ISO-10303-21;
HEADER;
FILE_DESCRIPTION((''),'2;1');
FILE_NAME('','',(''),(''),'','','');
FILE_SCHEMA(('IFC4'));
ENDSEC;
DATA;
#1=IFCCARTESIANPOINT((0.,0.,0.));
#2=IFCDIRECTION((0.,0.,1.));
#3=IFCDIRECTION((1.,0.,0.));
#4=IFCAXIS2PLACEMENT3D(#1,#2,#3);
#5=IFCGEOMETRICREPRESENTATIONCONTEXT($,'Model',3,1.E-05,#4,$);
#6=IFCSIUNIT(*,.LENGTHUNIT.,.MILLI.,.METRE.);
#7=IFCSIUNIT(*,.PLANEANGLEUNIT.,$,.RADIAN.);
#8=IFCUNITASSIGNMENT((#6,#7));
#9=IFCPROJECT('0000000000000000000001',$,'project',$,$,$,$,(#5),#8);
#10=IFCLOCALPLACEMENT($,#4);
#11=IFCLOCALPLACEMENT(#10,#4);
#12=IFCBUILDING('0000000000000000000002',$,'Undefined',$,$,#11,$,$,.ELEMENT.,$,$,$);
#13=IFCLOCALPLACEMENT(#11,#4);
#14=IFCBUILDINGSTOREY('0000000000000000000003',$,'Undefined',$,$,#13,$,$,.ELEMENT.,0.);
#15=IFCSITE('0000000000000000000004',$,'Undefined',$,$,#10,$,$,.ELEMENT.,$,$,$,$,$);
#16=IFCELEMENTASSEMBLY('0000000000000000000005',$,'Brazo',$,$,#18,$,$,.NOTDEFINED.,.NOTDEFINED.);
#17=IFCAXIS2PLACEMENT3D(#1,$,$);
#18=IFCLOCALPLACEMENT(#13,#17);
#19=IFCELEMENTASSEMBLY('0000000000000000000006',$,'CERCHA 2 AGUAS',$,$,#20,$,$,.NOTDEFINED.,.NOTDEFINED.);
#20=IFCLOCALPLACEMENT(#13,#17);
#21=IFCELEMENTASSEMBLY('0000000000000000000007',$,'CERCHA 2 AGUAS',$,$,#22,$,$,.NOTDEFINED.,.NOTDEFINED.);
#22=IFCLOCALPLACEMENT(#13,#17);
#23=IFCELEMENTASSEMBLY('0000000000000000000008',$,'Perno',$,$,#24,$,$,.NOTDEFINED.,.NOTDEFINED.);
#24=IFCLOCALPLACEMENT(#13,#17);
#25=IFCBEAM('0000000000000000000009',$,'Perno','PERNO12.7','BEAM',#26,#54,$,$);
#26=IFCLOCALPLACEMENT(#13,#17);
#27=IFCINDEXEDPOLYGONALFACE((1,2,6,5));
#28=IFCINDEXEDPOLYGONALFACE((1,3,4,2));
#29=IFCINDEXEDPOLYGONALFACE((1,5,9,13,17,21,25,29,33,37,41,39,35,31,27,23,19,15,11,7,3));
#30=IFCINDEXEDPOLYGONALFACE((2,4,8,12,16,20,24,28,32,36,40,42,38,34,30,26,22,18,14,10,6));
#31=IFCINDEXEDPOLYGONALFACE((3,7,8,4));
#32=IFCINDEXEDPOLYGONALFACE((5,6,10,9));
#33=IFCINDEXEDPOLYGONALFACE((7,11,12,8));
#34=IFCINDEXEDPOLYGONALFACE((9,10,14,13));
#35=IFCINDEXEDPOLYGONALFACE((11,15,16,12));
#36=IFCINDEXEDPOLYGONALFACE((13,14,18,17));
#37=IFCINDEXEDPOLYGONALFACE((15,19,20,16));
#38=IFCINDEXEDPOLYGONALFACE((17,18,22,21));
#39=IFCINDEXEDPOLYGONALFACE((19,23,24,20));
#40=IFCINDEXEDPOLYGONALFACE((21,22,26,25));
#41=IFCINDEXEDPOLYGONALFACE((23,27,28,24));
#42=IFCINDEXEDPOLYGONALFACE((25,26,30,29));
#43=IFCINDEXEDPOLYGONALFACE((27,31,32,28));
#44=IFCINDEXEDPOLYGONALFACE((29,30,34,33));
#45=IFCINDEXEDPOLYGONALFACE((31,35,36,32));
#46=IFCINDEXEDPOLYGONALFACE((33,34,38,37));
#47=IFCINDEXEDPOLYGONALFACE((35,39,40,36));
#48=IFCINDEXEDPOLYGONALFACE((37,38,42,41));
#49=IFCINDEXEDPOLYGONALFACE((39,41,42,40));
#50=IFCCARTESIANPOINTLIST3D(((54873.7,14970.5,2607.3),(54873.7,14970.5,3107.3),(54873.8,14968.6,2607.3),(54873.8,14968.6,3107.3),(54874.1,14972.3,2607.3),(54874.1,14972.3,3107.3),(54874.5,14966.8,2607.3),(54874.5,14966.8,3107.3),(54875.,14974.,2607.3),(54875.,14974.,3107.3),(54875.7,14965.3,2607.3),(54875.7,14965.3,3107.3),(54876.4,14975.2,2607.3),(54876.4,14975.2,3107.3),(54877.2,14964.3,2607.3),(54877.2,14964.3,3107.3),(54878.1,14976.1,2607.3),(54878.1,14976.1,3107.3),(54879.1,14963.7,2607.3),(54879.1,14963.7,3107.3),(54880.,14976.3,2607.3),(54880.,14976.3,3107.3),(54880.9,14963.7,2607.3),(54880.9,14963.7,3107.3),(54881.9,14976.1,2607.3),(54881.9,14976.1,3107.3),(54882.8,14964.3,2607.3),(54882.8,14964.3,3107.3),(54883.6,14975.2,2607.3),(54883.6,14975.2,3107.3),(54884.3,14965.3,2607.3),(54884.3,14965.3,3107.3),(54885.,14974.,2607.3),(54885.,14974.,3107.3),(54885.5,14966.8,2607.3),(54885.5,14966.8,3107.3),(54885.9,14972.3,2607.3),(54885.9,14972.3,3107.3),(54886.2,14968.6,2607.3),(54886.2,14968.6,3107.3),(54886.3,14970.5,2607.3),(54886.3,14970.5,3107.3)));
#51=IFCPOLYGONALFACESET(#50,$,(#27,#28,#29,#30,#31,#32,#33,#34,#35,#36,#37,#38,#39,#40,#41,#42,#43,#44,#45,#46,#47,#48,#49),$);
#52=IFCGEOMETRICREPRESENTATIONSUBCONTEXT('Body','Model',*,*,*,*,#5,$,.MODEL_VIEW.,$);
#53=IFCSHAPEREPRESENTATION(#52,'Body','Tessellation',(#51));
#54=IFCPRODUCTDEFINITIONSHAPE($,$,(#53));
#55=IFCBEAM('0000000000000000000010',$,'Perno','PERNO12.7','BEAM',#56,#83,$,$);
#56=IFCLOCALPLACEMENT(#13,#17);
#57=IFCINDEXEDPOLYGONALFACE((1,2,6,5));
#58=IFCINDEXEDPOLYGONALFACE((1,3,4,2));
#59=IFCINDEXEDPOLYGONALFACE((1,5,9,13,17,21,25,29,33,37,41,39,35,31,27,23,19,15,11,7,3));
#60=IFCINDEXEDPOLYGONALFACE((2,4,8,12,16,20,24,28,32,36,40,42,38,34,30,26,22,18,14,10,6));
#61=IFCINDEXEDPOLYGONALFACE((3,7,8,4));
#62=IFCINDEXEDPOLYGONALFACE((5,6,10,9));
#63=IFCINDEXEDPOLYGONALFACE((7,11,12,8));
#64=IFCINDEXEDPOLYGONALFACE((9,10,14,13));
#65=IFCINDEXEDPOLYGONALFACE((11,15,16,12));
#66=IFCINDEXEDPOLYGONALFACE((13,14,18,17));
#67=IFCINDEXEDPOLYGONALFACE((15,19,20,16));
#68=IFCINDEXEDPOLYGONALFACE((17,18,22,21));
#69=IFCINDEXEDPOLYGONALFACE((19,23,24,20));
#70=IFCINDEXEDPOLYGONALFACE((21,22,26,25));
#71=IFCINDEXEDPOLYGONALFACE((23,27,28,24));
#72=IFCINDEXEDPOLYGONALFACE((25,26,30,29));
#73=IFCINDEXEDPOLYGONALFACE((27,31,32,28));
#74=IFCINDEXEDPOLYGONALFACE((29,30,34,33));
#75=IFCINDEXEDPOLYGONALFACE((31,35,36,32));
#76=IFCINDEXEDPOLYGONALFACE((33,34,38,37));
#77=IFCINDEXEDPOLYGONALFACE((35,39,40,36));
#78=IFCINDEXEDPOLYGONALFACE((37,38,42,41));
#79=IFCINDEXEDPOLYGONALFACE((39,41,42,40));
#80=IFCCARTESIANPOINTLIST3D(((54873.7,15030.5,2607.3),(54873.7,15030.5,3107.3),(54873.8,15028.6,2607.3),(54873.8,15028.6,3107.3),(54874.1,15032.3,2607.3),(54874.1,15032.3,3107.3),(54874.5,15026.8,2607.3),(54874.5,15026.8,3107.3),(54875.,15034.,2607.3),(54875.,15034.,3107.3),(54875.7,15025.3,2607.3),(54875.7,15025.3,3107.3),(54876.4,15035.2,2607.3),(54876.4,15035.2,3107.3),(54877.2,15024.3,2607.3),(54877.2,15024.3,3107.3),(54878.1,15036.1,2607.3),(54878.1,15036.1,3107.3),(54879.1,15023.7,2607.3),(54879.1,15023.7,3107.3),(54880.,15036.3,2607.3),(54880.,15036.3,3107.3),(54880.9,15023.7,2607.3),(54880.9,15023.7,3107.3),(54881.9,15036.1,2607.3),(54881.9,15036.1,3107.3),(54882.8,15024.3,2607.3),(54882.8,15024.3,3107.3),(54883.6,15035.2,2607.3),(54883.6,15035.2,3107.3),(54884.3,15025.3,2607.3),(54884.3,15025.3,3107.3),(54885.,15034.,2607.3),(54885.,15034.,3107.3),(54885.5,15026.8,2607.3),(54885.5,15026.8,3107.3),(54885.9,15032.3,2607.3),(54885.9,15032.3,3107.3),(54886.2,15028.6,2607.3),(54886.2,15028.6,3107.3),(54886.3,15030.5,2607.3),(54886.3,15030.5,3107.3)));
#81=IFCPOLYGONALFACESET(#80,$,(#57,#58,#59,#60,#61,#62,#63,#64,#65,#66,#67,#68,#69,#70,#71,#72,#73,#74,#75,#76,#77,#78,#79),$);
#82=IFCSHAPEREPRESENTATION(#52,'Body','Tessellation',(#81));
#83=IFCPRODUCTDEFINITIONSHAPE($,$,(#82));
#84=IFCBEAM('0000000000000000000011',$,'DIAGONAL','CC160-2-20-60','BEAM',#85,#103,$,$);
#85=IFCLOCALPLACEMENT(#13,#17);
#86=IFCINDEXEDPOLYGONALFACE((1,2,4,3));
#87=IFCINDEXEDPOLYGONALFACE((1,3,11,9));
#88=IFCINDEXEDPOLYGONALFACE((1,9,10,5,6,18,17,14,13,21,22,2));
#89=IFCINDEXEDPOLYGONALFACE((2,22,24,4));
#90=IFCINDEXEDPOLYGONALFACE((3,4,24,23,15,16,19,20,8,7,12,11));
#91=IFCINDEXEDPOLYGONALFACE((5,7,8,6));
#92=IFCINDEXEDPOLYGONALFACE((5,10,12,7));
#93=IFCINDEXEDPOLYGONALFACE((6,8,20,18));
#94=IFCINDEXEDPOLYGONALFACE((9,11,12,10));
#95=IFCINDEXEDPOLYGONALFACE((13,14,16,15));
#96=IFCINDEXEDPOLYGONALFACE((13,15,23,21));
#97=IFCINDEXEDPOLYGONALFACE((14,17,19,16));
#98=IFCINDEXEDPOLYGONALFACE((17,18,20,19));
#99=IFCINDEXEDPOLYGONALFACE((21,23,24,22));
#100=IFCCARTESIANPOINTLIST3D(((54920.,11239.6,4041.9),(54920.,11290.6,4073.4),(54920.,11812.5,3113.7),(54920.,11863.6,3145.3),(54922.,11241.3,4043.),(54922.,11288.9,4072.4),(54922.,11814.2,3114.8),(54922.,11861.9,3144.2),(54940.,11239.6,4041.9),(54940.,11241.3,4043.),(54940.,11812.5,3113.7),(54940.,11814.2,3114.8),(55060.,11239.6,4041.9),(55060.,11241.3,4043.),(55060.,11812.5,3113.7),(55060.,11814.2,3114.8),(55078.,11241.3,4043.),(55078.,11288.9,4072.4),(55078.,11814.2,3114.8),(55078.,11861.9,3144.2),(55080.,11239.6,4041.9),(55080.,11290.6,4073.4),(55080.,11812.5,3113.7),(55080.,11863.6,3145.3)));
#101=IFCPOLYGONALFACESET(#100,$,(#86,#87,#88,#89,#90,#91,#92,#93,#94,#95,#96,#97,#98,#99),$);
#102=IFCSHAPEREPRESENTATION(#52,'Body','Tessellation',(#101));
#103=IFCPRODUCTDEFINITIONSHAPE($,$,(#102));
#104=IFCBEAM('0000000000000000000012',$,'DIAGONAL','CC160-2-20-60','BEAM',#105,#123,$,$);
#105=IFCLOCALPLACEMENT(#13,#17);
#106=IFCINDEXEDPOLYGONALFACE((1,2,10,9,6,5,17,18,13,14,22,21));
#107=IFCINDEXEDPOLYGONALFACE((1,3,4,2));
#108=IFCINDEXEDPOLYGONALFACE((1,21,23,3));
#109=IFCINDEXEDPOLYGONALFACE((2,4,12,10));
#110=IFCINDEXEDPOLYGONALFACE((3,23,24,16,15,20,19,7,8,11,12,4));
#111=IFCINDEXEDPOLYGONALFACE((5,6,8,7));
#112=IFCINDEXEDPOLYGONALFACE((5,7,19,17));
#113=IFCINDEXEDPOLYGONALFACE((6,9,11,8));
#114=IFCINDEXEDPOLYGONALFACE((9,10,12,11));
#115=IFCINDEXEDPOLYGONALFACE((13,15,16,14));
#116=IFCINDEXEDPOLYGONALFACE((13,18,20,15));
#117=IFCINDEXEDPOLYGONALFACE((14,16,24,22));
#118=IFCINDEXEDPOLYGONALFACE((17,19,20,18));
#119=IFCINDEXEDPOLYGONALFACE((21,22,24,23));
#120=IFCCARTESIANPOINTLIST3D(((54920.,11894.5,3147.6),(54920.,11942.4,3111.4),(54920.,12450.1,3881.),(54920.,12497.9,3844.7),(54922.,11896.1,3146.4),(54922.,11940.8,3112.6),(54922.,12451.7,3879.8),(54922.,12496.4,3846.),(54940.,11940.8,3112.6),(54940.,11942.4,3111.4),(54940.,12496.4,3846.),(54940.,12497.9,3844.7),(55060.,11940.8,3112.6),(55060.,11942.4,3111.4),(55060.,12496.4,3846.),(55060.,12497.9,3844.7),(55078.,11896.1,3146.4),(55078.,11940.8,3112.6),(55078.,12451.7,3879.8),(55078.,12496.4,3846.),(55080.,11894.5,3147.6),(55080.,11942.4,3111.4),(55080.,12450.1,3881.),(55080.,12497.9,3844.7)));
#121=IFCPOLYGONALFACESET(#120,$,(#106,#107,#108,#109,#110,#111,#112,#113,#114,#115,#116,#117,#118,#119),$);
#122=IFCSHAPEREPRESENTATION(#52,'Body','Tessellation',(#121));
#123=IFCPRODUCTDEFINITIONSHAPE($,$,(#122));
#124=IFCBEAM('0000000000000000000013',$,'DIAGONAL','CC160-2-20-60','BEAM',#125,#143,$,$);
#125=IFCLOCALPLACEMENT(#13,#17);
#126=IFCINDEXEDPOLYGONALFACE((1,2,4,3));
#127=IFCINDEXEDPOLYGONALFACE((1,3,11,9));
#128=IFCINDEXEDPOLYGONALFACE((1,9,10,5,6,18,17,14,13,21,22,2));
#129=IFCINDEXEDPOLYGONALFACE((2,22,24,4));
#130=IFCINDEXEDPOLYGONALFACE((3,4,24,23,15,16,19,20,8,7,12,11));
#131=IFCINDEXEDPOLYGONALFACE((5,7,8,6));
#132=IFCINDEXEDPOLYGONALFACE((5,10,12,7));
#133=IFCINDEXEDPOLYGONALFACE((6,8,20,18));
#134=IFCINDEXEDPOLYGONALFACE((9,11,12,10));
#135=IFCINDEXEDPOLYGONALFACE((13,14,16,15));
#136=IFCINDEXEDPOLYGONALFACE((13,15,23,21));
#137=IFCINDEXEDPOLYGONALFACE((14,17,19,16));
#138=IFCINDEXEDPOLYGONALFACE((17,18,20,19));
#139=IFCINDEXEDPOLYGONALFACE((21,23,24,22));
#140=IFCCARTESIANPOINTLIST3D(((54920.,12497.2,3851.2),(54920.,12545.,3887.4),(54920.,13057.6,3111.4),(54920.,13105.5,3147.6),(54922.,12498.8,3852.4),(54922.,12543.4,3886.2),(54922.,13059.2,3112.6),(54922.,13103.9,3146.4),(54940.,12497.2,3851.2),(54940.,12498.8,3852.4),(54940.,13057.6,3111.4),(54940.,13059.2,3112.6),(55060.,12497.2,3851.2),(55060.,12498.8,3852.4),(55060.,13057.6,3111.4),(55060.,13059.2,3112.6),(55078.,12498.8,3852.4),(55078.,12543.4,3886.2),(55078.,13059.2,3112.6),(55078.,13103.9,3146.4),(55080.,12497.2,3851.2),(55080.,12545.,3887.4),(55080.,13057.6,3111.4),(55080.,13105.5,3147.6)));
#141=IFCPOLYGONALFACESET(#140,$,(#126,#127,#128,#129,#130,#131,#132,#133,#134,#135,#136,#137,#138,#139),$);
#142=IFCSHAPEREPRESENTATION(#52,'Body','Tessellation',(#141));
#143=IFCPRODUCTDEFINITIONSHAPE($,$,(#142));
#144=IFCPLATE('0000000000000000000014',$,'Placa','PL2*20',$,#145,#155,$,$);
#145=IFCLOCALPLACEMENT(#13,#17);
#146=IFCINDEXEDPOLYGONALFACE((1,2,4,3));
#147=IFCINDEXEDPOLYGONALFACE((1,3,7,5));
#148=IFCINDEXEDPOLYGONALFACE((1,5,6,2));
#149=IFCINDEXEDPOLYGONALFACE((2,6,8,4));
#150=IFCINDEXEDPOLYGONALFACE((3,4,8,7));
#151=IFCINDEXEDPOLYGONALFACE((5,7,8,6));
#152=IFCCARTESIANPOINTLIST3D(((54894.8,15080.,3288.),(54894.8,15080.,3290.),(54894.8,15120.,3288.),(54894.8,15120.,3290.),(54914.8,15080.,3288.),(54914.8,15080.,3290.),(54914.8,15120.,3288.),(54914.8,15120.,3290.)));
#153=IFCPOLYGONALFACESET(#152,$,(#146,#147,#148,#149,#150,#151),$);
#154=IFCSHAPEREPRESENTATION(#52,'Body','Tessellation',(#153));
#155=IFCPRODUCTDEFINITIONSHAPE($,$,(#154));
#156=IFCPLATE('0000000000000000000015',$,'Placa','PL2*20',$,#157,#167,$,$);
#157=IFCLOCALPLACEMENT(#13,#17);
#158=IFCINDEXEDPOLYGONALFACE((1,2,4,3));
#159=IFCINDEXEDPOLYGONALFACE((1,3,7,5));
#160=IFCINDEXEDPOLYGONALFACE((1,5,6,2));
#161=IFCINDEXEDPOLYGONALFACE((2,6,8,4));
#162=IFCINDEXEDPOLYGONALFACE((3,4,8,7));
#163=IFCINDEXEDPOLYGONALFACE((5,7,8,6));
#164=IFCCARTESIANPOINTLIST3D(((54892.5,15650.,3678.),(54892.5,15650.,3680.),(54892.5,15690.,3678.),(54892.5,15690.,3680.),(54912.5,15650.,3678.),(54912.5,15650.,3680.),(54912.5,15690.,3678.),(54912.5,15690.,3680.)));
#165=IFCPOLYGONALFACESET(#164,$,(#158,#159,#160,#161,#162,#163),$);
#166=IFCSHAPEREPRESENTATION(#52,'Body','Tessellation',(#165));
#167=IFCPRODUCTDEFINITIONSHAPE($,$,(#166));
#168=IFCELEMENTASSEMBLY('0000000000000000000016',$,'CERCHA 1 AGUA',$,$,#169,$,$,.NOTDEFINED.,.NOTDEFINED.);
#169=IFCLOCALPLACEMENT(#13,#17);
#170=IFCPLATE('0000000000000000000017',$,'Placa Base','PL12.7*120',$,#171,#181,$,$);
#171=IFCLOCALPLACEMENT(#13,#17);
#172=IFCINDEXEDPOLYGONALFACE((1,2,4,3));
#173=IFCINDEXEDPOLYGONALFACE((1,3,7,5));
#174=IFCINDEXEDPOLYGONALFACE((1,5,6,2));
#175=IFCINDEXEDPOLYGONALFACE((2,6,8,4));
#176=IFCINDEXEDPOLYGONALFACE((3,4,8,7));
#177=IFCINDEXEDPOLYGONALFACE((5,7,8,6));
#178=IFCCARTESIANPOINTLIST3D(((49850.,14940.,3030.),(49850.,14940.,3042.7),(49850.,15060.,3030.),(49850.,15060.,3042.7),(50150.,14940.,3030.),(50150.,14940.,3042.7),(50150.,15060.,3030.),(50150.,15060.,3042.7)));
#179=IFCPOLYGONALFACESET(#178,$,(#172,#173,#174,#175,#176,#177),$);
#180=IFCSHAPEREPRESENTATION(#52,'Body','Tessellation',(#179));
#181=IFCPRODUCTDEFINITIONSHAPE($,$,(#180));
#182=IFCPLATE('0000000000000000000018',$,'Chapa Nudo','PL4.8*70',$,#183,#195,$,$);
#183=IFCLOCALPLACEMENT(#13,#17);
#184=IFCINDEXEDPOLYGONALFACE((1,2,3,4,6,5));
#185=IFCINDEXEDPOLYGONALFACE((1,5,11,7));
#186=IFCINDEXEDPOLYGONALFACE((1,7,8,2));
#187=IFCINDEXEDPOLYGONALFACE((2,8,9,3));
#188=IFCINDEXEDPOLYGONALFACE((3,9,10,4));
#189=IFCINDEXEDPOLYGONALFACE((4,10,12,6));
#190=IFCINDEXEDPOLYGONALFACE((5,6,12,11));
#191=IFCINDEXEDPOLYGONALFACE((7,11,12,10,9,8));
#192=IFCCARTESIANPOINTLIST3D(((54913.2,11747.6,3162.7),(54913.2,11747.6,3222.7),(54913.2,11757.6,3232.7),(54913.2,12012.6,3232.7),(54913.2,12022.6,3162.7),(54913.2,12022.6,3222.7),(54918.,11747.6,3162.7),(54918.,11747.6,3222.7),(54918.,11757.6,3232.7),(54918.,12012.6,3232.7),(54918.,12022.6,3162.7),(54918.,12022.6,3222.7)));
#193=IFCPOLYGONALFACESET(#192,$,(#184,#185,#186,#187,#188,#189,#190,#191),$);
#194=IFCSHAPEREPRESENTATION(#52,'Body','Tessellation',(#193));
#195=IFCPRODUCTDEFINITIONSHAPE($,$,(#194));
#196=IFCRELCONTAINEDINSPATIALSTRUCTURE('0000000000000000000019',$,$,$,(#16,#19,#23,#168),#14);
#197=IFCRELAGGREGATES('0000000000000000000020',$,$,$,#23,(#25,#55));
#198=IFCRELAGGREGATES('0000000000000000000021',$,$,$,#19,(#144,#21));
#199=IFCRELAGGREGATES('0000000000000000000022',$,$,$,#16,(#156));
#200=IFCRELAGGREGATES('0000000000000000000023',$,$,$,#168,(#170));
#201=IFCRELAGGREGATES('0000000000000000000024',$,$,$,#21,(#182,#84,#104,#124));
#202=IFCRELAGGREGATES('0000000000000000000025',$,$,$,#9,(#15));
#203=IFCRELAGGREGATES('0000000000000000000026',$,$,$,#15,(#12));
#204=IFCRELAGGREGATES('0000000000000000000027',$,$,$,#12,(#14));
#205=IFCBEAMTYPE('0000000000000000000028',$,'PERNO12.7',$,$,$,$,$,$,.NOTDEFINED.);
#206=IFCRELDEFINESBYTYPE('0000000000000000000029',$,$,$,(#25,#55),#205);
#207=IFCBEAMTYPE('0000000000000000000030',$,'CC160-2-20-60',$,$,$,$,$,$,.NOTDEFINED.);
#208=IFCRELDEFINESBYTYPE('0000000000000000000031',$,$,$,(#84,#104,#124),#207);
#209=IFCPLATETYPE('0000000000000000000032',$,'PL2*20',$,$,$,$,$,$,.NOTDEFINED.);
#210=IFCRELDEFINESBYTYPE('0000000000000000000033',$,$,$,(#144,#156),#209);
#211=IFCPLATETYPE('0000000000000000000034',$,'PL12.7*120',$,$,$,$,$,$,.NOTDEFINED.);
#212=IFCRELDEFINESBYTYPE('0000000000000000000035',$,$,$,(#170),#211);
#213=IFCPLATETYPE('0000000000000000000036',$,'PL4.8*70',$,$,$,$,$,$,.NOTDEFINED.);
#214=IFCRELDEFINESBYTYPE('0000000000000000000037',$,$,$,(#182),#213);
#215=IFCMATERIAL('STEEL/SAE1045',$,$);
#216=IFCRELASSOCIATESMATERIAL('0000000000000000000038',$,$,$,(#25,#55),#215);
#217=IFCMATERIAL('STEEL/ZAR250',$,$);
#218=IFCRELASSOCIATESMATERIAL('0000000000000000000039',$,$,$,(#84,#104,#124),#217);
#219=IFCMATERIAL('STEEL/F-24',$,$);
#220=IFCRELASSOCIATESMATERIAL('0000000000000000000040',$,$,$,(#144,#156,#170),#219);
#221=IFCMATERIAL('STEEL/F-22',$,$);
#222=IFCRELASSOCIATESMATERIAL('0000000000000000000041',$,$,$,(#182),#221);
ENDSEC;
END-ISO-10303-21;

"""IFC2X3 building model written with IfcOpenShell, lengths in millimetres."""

from ifc_helpers import new_model, si_unit, frame, origin_with_axes, origin_2d_with_axis, place, context, subcontext, project, spatial, polyline, circle, c_section, outline, extrude, material, type_object, element, aggregate, save


model = new_model("IFC2X3")

# Units and contexts
model_context = context("Model", 3, precision=1e-05, world=origin_with_axes())
body_context = subcontext(model_context, "Body", "Model", "MODEL_VIEW")
ifc_project = project(units=[si_unit("LENGTHUNIT", "METRE", prefix="MILLI"), si_unit("PLANEANGLEUNIT", "RADIAN")], contexts=[model_context])

# Site, building, storey
site_placement = place(None, origin_with_axes())
site = spatial("IfcSite", under=ifc_project, at=site_placement, Name="Undefined", CompositionType="ELEMENT")
building_placement = place(site_placement, origin_with_axes())
building = spatial("IfcBuilding", under=site, at=building_placement, Name="Undefined", CompositionType="ELEMENT")
storey_placement = place(building_placement, origin_with_axes())
storey = spatial("IfcBuildingStorey", under=building, at=storey_placement, Name="Undefined", CompositionType="ELEMENT", Elevation=0.0)

# Element assembly
assembly_1_placement = place(storey_placement, origin_with_axes())
assembly_1 = element("IfcElementAssembly", 1, at=assembly_1_placement, inside=storey, Name="Brazo", AssemblyPlace="NOTDEFINED", PredefinedType="NOTDEFINED")
ifc_material_1 = material(Name="STEEL/ZAR250")

# Element assemblies
assembly_2_placement = place(storey_placement, origin_with_axes())
assembly_2 = element("IfcElementAssembly", 2, at=assembly_2_placement, inside=storey, Name="CERCHA 2 AGUAS", AssemblyPlace="NOTDEFINED", PredefinedType="NOTDEFINED")
assembly_3_placement = place(assembly_2_placement, origin_with_axes())
assembly_3 = element("IfcElementAssembly", 3, at=assembly_3_placement, Name="CERCHA 2 AGUAS", AssemblyPlace="NOTDEFINED", PredefinedType="NOTDEFINED")
ifc_material_2 = material(Name="STEEL/F-22")

# Element assembly, beams
assembly_4_placement = place(storey_placement, origin_with_axes())
assembly_4 = element("IfcElementAssembly", 4, at=assembly_4_placement, inside=storey, Name="Perno", AssemblyPlace="NOTDEFINED", PredefinedType="NOTDEFINED")
ifc_material_3 = material(Name="STEEL/SAE1045")
beam_type_1 = type_object("IfcBeamType", Name="PERNO12.7", PredefinedType="NOTDEFINED")
beam_1_placement = place(assembly_4_placement, frame((54880.0, 14970.0, 3107.3), z_axis=(-1.0, 0.0, 0.0), x_axis=(0.0, 0.0, -1.0)))
beam_1 = element("IfcBeam", 5, at=beam_1_placement, type_object=beam_type_1, material=ifc_material_3, Name="Perno", Description="PERNO12.7", ObjectType="BEAM", context=body_context, shape_type="SweptSolid", body=[
    extrude(circle(Radius=6.3, at=origin_2d_with_axis()), frame((500.0, 0.0, 0.0), z_axis=(-1.0, 0.0, 0.0), x_axis=(0.0, -1.0, 0.0)), (0.0, 0.0, 1.0), 500.0),
])
beam_2_placement = place(assembly_4_placement, frame((54880.0, 15030.0, 3107.3), z_axis=(-1.0, 0.0, 0.0), x_axis=(0.0, 0.0, -1.0)))
beam_2 = element("IfcBeam", 6, at=beam_2_placement, type_object=beam_type_1, material=ifc_material_3, Name="Perno", Description="PERNO12.7", ObjectType="BEAM", context=body_context, shape_type="SweptSolid", body=[
    extrude(circle(Radius=6.3, at=origin_2d_with_axis()), frame((500.0, 0.0, 0.0), z_axis=(-1.0, 0.0, 0.0), x_axis=(0.0, -1.0, 0.0)), (0.0, 0.0, 1.0), 500.0),
])
aggregate(assembly_4, [beam_1, beam_2])

# Beams
beam_type_2 = type_object("IfcBeamType", Name="CC160-2-20-60", PredefinedType="NOTDEFINED")
beam_3_placement = place(assembly_3_placement, frame((55000.0, 11838.1, 3129.5), z_axis=(-1.0, 0.0, 0.0), x_axis=(0.0, -0.525269, 0.850936)))
beam_3 = element("IfcBeam", 7, at=beam_3_placement, type_object=beam_type_2, material=ifc_material_1, Name="DIAGONAL", Description="CC160-2-20-60", ObjectType="BEAM", context=body_context, shape_type="SweptSolid", body=[
    extrude(c_section(Depth=160.0, Width=60.0, WallThickness=2.0, Girth=20.0, at=origin_2d_with_axis()), frame((1090.8, 0.0, 0.0), z_axis=(-1.0, 0.0, 0.0), x_axis=(0.0, -1.0, 0.0)), (0.0, 0.0, 1.0), 1090.8),
])
beam_4_placement = place(assembly_3_placement, frame((55000.0, 12474.0, 3862.9), z_axis=(-1.0, 0.0, 0.0), x_axis=(0.0, -0.603858, -0.797092)))
beam_4 = element("IfcBeam", 8, at=beam_4_placement, type_object=beam_type_2, material=ifc_material_1, Name="DIAGONAL", Description="CC160-2-20-60", ObjectType="BEAM", context=body_context, shape_type="SweptSolid", body=[
    extrude(c_section(Depth=160.0, Width=60.0, WallThickness=2.0, Girth=20.0, at=origin_2d_with_axis()), frame((920.0, 0.0, 0.0), z_axis=(-1.0, 0.0, 0.0), x_axis=(0.0, -1.0, 0.0)), (0.0, 0.0, 1.0), 920.0),
])
beam_5_placement = place(assembly_3_placement, frame((55000.0, 13081.5, 3129.5), z_axis=(-1.0, 0.0, 0.0), x_axis=(0.0, -0.603858, 0.797092)))
beam_5 = element("IfcBeam", 9, at=beam_5_placement, type_object=beam_type_2, material=ifc_material_1, Name="DIAGONAL", Description="CC160-2-20-60", ObjectType="BEAM", context=body_context, shape_type="SweptSolid", body=[
    extrude(c_section(Depth=160.0, Width=60.0, WallThickness=2.0, Girth=20.0, at=origin_2d_with_axis()), frame((928.1, 0.0, 0.0), z_axis=(-1.0, 0.0, 0.0), x_axis=(0.0, -1.0, 0.0)), (0.0, 0.0, 1.0), 928.1),
])

# Plates
ifc_material_4 = material(Name="STEEL/F-24")
plate_type_1 = type_object("IfcPlateType", Name="PL2*20", PredefinedType="NOTDEFINED")
plate_1_placement = place(assembly_2_placement, frame((54914.8, 15120.0, 3289.0), z_axis=(0.0, -0.000121, -1.0), x_axis=(0.000085, -1.0, 0.000121)))
plate_1 = element("IfcPlate", 10, at=plate_1_placement, type_object=plate_type_1, material=ifc_material_4, Name="Placa", Description="PL2*20", context=body_context, shape_type="SweptSolid", body=[
    extrude(outline(polyline([(0.0, 0.0), (40.0, 0.0), (40.0, 20.0), (0.0, 20.0), (0.0, 0.0)])), frame((0.0, 0.0, -1.0), z_axis=(0.0, 0.0, 1.0), x_axis=(1.0, 0.0, 0.0)), (0.0, 0.0, 1.0), 2.0),
])
aggregate(assembly_2, [plate_1, assembly_3])
plate_2_placement = place(assembly_1_placement, frame((54912.5, 15690.0, 3679.0), z_axis=(0.0, -0.000121, -1.0), x_axis=(0.000085, -1.0, 0.000121)))
plate_2 = element("IfcPlate", 11, at=plate_2_placement, type_object=plate_type_1, material=ifc_material_4, Name="Placa", Description="PL2*20", context=body_context, shape_type="SweptSolid", body=[
    extrude(outline(polyline([(0.0, 0.0), (40.0, 0.0), (40.0, 20.0), (0.0, 20.0), (0.0, 0.0)])), frame((0.0, 0.0, -1.0), z_axis=(0.0, 0.0, 1.0), x_axis=(1.0, 0.0, 0.0)), (0.0, 0.0, 1.0), 2.0),
])
aggregate(assembly_1, [plate_2])

# Element assembly, plate
assembly_5_placement = place(storey_placement, origin_with_axes())
assembly_5 = element("IfcElementAssembly", 12, at=assembly_5_placement, inside=storey, Name="CERCHA 1 AGUA", AssemblyPlace="NOTDEFINED", PredefinedType="NOTDEFINED")
plate_type_2 = type_object("IfcPlateType", Name="PL12.7*120", PredefinedType="NOTDEFINED")
plate_3_placement = place(assembly_5_placement, frame((50150.0, 15060.0, 3036.3), z_axis=(0.0, 0.0, 1.0), x_axis=(-1.0, 0.0, 0.0)))
plate_3 = element("IfcPlate", 13, at=plate_3_placement, type_object=plate_type_2, material=ifc_material_4, Name="Placa Base", Description="PL12.7*120", context=body_context, shape_type="SweptSolid", body=[
    extrude(outline(polyline([(0.0, 0.0), (300.0, 0.0), (300.0, 120.0), (0.0, 120.0), (0.0, 0.0)])), frame((0.0, 0.0, -6.3), z_axis=(0.0, 0.0, 1.0), x_axis=(1.0, 0.0, 0.0)), (0.0, 0.0, 1.0), 12.7),
])
aggregate(assembly_5, [plate_3])

# Plate
plate_type_3 = type_object("IfcPlateType", Name="PL4.8*70", PredefinedType="NOTDEFINED")
plate_4_placement = place(assembly_3_placement, frame((54915.6, 12022.6, 3232.7), z_axis=(-1.0, 0.0, 0.0), x_axis=(0.0, 0.0, -1.0)))
plate_4 = element("IfcPlate", 14, at=plate_4_placement, type_object=plate_type_3, material=ifc_material_2, Name="Chapa Nudo", Description="PL4.8*70", context=body_context, shape_type="SweptSolid", body=[
    extrude(outline(polyline([(0.0, 10.0), (10.0, 0.0), (70.0, 0.0), (70.0, 275.0), (10.0, 275.0), (0.0, 265.0), (0.0, 10.0)])), frame((0.0, 0.0, -2.4), z_axis=(0.0, 0.0, 1.0), x_axis=(1.0, 0.0, 0.0)), (0.0, 0.0, 1.0), 4.8),
])

aggregate(assembly_3, [plate_4, beam_3, beam_4, beam_5])

save(model, "model.ifc")
